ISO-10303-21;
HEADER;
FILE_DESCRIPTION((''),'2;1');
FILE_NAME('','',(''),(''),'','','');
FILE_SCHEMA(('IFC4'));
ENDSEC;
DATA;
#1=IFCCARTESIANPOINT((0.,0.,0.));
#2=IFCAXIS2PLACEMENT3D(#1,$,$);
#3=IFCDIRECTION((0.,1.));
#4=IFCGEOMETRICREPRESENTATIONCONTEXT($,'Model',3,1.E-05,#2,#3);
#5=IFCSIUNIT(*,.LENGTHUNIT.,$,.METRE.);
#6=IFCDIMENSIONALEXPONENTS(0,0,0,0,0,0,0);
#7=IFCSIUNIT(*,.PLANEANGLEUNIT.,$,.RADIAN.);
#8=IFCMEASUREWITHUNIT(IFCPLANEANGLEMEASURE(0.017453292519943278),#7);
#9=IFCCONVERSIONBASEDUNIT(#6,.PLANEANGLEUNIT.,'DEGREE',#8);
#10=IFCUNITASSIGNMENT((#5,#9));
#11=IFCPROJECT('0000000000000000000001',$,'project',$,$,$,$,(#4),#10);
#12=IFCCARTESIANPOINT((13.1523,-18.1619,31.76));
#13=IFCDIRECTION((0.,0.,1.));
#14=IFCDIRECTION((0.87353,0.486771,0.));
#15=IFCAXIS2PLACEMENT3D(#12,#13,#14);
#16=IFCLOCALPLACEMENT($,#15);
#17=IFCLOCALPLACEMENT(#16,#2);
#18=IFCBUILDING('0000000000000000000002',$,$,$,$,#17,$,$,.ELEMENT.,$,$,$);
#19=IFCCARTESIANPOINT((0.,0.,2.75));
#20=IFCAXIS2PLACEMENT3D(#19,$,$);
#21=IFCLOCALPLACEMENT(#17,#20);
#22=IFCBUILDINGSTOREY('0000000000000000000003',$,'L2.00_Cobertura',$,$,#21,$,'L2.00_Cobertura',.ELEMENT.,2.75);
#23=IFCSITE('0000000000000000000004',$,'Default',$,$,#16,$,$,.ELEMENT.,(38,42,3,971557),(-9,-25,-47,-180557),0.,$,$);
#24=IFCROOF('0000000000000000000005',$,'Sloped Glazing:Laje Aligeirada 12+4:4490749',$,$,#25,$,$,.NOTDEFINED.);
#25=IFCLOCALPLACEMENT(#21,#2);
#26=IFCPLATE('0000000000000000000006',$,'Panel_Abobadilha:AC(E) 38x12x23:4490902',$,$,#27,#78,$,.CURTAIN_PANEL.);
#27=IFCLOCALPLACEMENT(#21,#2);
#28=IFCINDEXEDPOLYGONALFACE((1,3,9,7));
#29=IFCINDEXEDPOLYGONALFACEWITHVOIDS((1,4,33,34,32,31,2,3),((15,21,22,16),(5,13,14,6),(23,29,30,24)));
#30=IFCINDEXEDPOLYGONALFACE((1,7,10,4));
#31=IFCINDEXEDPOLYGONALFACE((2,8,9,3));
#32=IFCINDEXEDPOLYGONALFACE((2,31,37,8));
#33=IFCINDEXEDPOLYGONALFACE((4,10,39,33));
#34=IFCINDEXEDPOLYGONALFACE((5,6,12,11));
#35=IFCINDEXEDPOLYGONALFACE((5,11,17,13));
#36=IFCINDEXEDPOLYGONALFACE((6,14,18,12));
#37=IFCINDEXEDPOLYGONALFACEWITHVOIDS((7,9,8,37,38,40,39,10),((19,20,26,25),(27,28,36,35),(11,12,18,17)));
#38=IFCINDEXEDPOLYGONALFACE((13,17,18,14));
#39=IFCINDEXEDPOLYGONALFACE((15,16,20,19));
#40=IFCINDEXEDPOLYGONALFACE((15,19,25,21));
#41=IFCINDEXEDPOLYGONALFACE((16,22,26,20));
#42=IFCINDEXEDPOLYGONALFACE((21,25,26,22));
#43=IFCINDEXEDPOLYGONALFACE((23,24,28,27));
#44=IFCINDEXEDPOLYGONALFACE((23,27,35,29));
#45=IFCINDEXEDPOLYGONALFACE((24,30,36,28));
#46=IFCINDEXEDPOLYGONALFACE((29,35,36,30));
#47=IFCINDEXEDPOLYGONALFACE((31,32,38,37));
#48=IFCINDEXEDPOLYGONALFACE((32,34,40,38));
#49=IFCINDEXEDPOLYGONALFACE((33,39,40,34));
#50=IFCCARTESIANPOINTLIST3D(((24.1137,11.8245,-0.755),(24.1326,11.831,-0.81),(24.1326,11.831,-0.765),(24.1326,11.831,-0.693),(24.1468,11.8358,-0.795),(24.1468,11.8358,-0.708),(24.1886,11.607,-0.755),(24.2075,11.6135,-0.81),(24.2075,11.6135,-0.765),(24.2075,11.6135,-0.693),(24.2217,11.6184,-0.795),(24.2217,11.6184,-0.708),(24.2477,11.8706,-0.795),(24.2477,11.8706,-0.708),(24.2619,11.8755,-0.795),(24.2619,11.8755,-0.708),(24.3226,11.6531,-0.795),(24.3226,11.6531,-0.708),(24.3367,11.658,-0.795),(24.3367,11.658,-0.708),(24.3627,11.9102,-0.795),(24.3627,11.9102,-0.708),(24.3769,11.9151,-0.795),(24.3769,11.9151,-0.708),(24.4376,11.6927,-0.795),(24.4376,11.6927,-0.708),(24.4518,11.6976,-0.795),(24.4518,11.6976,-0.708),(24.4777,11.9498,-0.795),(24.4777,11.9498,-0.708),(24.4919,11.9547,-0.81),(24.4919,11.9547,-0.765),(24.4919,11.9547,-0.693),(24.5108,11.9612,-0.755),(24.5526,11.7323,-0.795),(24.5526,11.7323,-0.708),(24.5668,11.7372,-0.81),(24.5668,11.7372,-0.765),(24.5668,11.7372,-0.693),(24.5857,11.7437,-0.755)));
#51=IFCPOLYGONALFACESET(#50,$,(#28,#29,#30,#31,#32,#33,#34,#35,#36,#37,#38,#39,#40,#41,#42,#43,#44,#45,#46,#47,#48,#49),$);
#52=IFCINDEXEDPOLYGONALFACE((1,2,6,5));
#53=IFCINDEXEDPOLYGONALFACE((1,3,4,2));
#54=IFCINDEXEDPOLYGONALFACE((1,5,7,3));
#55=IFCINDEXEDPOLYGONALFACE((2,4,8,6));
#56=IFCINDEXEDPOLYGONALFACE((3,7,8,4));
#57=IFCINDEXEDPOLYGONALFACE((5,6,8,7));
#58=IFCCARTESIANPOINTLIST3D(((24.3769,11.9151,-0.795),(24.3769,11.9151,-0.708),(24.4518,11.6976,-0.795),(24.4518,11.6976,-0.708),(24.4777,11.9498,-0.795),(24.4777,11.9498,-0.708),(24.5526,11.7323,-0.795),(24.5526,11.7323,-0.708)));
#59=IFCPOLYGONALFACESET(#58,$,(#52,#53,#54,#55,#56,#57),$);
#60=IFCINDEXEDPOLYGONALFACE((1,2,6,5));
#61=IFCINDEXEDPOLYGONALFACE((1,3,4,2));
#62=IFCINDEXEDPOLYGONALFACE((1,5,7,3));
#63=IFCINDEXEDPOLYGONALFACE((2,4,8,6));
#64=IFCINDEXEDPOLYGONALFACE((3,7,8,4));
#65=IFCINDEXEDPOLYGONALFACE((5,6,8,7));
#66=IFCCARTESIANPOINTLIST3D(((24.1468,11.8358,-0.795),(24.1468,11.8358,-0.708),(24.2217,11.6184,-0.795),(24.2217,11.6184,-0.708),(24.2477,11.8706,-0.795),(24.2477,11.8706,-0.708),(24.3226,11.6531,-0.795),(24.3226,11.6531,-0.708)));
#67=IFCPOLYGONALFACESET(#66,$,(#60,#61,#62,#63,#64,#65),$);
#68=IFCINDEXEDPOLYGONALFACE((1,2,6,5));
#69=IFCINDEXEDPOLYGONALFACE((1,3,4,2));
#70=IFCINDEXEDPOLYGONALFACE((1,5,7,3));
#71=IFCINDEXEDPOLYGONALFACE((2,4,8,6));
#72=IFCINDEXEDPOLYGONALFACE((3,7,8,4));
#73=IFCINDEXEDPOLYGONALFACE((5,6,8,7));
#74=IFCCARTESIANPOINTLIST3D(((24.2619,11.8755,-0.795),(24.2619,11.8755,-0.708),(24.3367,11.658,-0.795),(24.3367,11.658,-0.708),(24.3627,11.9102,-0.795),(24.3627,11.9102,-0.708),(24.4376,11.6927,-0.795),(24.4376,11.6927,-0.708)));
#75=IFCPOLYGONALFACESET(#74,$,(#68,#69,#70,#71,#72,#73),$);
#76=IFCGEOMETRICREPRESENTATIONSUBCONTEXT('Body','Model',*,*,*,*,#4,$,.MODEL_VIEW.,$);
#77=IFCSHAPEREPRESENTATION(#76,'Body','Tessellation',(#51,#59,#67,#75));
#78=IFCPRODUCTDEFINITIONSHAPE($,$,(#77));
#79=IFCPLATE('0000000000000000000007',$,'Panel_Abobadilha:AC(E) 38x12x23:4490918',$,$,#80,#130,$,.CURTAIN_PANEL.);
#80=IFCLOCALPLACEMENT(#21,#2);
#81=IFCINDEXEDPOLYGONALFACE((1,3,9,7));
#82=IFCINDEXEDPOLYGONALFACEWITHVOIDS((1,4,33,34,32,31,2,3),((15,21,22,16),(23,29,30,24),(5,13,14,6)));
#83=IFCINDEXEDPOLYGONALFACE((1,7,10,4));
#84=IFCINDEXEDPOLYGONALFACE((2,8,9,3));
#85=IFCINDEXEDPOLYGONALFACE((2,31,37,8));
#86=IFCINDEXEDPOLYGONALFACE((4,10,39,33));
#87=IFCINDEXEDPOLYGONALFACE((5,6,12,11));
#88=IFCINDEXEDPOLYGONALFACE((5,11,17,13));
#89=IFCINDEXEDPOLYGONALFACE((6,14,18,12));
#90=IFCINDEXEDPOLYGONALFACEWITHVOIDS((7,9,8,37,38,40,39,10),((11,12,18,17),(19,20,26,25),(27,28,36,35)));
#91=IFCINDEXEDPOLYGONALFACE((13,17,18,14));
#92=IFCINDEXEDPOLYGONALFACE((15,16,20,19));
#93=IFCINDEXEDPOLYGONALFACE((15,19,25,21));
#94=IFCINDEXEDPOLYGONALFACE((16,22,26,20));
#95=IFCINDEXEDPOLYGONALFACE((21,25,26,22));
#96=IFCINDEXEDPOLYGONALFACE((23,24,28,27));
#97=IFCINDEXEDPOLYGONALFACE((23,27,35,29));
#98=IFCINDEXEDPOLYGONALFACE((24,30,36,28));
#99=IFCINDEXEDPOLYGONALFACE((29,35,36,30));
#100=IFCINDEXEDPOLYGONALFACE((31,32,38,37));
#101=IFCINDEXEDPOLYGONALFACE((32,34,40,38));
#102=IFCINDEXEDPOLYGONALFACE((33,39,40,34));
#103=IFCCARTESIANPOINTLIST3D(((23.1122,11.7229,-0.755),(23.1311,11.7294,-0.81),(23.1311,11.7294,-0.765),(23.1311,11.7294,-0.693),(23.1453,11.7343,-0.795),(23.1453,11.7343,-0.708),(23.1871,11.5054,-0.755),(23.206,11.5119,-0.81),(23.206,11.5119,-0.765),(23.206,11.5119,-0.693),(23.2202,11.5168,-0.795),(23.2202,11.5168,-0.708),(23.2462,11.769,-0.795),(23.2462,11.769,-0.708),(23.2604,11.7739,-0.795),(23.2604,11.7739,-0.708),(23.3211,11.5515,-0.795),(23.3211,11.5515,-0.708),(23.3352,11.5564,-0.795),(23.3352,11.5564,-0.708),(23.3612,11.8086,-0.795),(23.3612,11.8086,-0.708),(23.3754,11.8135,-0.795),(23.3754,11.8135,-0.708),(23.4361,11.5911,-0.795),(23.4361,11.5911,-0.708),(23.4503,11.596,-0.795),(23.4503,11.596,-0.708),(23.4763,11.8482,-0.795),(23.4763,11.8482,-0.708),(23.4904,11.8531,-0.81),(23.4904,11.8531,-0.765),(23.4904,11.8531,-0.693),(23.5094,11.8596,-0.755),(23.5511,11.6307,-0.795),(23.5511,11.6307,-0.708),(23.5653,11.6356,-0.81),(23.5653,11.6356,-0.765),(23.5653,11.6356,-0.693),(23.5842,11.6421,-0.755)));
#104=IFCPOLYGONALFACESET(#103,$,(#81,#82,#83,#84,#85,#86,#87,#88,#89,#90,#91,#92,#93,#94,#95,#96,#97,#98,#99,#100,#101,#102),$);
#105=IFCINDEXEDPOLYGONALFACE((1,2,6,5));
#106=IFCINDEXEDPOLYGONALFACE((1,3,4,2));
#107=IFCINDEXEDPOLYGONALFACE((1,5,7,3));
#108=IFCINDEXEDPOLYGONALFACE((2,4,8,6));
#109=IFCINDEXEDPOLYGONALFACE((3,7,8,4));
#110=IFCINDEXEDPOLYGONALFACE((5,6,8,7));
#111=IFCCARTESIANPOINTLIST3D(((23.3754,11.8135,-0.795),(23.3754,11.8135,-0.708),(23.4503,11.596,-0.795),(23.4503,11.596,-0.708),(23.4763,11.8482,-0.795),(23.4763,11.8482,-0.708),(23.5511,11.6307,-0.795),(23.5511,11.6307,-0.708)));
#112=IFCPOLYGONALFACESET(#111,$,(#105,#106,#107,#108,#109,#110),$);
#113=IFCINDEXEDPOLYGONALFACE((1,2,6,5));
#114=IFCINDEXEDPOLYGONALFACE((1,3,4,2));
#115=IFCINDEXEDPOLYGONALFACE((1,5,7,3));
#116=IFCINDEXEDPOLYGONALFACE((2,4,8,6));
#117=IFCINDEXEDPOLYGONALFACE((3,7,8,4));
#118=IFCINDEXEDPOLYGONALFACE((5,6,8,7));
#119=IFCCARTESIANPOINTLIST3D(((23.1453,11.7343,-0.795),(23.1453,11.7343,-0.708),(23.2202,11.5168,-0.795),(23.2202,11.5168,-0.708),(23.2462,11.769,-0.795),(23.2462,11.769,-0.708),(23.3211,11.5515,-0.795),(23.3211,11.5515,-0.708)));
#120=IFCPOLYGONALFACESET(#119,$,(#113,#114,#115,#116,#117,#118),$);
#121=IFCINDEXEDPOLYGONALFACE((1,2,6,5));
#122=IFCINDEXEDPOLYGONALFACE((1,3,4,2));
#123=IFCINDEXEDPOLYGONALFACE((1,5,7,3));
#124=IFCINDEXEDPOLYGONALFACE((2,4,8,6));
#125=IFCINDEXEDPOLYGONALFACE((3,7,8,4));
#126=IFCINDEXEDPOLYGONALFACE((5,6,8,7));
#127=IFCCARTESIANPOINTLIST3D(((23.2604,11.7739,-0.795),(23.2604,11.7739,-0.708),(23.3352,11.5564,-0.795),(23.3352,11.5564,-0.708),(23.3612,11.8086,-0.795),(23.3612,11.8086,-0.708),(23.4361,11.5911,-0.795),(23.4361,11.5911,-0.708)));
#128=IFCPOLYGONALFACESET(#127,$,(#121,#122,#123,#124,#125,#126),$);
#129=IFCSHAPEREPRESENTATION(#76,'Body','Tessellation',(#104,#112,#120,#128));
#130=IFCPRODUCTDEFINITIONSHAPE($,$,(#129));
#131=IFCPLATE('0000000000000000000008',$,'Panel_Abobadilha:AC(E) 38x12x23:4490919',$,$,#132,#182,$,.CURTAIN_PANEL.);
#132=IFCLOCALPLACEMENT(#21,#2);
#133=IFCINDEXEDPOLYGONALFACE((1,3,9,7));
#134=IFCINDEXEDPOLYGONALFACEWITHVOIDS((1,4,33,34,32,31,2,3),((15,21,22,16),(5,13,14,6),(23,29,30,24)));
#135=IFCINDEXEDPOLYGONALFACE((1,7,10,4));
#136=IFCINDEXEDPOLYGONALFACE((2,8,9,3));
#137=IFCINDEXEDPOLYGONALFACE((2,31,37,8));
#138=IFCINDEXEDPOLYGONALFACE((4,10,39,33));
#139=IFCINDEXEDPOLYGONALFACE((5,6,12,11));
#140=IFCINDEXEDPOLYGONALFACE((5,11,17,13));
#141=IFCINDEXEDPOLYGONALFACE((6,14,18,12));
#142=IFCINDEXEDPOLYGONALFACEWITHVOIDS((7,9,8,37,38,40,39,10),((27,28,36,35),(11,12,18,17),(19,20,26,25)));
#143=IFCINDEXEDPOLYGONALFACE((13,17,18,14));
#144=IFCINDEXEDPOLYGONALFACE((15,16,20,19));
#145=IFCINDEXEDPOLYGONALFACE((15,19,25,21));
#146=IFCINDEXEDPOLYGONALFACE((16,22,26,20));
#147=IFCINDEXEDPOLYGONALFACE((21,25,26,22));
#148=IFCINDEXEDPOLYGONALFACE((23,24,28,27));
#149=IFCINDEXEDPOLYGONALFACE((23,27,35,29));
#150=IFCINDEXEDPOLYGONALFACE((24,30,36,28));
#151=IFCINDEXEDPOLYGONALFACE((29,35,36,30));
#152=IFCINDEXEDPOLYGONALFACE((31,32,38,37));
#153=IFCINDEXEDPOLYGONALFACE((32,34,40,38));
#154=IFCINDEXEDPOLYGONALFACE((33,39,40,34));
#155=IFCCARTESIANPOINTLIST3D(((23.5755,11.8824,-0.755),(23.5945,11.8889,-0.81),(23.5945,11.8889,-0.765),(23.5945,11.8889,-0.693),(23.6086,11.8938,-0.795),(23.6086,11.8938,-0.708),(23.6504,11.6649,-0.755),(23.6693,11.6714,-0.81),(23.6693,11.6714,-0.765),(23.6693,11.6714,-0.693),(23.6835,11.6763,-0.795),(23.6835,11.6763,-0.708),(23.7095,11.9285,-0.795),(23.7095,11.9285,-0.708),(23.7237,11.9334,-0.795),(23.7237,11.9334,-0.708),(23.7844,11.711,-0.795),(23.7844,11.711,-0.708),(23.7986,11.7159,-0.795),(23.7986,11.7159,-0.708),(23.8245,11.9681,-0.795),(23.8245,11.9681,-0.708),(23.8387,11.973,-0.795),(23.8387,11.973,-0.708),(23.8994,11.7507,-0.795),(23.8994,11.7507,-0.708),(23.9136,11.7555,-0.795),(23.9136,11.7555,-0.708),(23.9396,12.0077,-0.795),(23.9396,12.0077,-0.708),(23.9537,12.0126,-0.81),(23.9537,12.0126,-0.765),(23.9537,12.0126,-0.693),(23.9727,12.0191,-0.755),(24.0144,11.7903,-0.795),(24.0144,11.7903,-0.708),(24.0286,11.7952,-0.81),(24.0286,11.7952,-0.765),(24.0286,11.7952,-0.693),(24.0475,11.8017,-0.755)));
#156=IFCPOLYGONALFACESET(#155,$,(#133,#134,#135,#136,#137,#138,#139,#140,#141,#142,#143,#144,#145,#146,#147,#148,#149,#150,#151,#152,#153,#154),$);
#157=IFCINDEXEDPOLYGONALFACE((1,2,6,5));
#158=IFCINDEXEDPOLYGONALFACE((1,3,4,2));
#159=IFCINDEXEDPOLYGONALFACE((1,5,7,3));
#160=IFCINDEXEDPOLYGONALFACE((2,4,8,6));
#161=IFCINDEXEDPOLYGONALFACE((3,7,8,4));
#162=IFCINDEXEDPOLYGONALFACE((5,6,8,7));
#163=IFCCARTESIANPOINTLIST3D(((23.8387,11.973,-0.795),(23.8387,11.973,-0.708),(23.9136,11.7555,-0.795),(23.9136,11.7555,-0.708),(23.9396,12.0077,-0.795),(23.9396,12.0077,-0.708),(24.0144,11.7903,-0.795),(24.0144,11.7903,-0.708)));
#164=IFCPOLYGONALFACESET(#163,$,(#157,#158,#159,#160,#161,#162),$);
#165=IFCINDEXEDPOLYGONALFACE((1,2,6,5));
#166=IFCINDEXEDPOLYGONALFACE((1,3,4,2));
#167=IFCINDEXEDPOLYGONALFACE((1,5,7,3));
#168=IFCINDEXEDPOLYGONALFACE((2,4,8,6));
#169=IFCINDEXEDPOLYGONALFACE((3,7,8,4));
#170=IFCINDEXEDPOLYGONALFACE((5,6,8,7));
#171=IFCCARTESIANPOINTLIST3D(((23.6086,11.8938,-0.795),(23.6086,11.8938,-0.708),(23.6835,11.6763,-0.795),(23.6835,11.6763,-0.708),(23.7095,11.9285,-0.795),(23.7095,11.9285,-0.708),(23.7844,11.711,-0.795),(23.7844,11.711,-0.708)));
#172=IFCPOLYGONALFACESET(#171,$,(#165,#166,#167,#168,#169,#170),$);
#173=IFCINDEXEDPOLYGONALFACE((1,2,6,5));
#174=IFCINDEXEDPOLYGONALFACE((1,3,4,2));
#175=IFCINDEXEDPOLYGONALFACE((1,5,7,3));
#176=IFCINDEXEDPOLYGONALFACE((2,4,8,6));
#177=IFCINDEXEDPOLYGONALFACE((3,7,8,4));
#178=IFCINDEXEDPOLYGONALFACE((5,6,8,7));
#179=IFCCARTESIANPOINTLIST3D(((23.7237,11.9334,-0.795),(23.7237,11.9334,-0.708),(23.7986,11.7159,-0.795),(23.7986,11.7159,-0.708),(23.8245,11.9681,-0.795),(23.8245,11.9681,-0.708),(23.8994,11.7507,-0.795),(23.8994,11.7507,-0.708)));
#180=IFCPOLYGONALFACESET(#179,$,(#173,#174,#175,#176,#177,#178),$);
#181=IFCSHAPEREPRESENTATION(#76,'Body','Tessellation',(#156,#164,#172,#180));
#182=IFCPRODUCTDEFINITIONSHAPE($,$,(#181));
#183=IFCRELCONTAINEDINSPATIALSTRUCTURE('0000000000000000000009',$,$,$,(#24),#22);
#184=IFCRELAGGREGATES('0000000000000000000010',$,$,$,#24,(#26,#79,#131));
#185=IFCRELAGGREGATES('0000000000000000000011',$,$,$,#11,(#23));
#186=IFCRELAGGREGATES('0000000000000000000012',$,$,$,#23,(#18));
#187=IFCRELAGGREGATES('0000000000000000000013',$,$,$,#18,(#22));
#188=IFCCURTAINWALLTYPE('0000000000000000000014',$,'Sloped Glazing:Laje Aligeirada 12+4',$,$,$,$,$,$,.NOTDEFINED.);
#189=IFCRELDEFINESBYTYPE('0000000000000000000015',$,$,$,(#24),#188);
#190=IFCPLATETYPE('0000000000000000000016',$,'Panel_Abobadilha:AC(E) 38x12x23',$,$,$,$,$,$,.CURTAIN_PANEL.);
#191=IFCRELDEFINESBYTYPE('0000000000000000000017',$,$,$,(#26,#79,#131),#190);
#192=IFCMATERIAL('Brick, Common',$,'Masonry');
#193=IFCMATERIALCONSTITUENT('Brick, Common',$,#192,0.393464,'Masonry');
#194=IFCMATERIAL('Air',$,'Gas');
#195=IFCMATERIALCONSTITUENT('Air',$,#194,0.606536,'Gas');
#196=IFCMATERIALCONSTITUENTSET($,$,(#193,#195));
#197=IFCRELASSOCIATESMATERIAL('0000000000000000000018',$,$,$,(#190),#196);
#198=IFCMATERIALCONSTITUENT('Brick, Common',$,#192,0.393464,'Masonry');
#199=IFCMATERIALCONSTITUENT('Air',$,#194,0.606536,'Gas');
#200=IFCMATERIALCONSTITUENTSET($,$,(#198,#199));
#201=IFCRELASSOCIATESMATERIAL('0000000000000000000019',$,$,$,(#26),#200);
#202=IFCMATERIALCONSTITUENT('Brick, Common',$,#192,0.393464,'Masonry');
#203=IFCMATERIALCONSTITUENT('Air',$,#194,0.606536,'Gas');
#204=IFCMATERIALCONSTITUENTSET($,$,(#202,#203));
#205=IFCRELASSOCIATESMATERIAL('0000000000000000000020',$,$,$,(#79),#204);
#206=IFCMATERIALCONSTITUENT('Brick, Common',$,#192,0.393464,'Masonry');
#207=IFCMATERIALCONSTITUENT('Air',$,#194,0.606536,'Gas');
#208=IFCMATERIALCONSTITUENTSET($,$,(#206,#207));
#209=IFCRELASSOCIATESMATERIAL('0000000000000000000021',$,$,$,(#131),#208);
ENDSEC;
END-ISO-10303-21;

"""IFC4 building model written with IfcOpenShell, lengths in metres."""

from ifc_helpers import new_model, entity, si_unit, converted_unit, direction, frame, origin, place, context, subcontext, project, spatial, indexed_curve, outline, extrude, source, transform, mapped, material, constituent, constituent_set, type_object, type_shapes, element, aggregate, save


model = new_model("IFC4")

# Units and contexts
model_context = context("Model", 3, precision=1e-05, world=origin(), true_north=direction((0.0, 1.0)))
body_context = subcontext(model_context, "Body", "Model", "MODEL_VIEW")
ifc_project = project(units=[si_unit("LENGTHUNIT", "METRE"), converted_unit("PLANEANGLEUNIT", "DEGREE", entity("IfcPlaneAngleMeasure", 0.017453292519943278), si_unit("PLANEANGLEUNIT", "RADIAN"), dimensions=[0, 0, 0, 0, 0, 0, 0])], contexts=[model_context])

# Site, building, storey
site_placement = place(None, frame((13.1523, -18.1619, 31.76), z_axis=(0.0, 0.0, 1.0), x_axis=(0.87353, 0.486771, 0.0)))
site = spatial("IfcSite", under=ifc_project, at=site_placement, Name="Default", CompositionType="ELEMENT", RefLatitude=(38, 42, 3, 971557), RefLongitude=(-9, -25, -47, -180557), RefElevation=0.0)
building_placement = place(site_placement, origin())
building = spatial("IfcBuilding", under=site, at=building_placement, CompositionType="ELEMENT")
storey_placement = place(building_placement, frame((0.0, 0.0, 2.75)))
storey = spatial("IfcBuildingStorey", under=building, at=storey_placement, Name="L2.00_Cobertura", LongName="L2.00_Cobertura", CompositionType="ELEMENT", Elevation=2.75)

# Roof, plates
curtain_wall_type = type_object("IfcCurtainWallType", Name="Sloped Glazing:Laje Aligeirada 12+4", PredefinedType="NOTDEFINED")
roof_placement = place(storey_placement, frame((0.0, 0.0, -2.75)))
roof = element("IfcRoof", 1, at=roof_placement, inside=storey, type_object=curtain_wall_type, Name="Sloped Glazing:Laje Aligeirada 12+4:4490749", PredefinedType="NOTDEFINED")
ifc_material_1 = material(Name="Brick, Common", Category="Masonry")
ifc_material_2 = material(Name="Air", Category="Gas")
ifc_constituent_1 = constituent(ifc_material_1, Name="Brick, Common", Category="Masonry", fraction=0.393464)
ifc_constituent_2 = constituent(ifc_material_2, Name="Air", Category="Gas", fraction=0.606536)
ifc_constituent_set_1 = constituent_set(constituents=[ifc_constituent_1, ifc_constituent_2])
plate_type_1 = type_object("IfcPlateType", Name="Panel_Abobadilha:AC(E) 38x12x23", PredefinedType="CURTAIN_PANEL", material=ifc_constituent_set_1)
shared_shape_1 = source(origin(), body_context, "Body", "SweptSolid", [
    extrude(outline(indexed_curve([(-0.19, -0.0543), (0.19, -0.0543), (0.19, -0.0093), (0.21, 0.0007), (0.19, 0.0628), (-0.19, 0.0628), (-0.21, 0.0007), (-0.19, -0.0093), (-0.19, -0.0543)], self_intersect=False), holes=[indexed_curve([(-0.0683, 0.0477), (-0.0683, -0.0393), (-0.175, -0.0393), (-0.175, 0.0477), (-0.0683, 0.0477)], self_intersect=False), indexed_curve([(0.0533, 0.0477), (0.0533, -0.0393), (-0.0533, -0.0393), (-0.0533, 0.0477), (0.0533, 0.0477)], self_intersect=False), indexed_curve([(0.175, 0.0477), (0.175, -0.0393), (0.0683, -0.0393), (0.0683, 0.0477), (0.175, 0.0477)], self_intersect=False)]), frame((0.0, 0.0543, 0.0)), (0.0, 0.0, 1.0), 0.23),
    extrude(outline(indexed_curve([(-0.0533, -0.0435), (0.0533, -0.0435), (0.0533, 0.0435), (-0.0533, 0.0435), (-0.0533, -0.0435)], self_intersect=False)), frame((0.1217, 0.0585, 0.0), z_axis=(0.0, 0.0, 1.0), x_axis=(-1.0, 0.0, 0.0)), (0.0, 0.0, 1.0), 0.23),
    extrude(outline(indexed_curve([(-0.0533, -0.0435), (0.0533, -0.0435), (0.0533, 0.0435), (-0.0533, 0.0435), (-0.0533, -0.0435)], self_intersect=False)), frame((-0.1217, 0.0585, 0.0), z_axis=(0.0, 0.0, 1.0), x_axis=(-1.0, 0.0, 0.0)), (0.0, 0.0, 1.0), 0.23),
    extrude(outline(indexed_curve([(-0.0533, -0.0435), (0.0533, -0.0435), (0.0533, 0.0435), (-0.0533, 0.0435), (-0.0533, -0.0435)], self_intersect=False)), frame((0.0, 0.0585, 0.0), z_axis=(0.0, 0.0, 1.0), x_axis=(-1.0, 0.0, 0.0)), (0.0, 0.0, 1.0), 0.23),
])
type_shapes(plate_type_1, [shared_shape_1])
ifc_constituent_3 = constituent(ifc_material_1, Name="Brick, Common", Category="Masonry", fraction=0.393464)
ifc_constituent_4 = constituent(ifc_material_2, Name="Air", Category="Gas", fraction=0.606536)
ifc_constituent_set_2 = constituent_set(constituents=[ifc_constituent_3, ifc_constituent_4])
plate_1_placement = place(roof_placement, frame((24.3123, 11.8928, 1.94), z_axis=(0.325568, -0.945519, 0.0), x_axis=(0.945519, 0.325568, 0.0)))
plate_1 = element("IfcPlate", 2, at=plate_1_placement, type_object=plate_type_1, material=ifc_constituent_set_2, Name="Panel_Abobadilha:AC(E) 38x12x23:4490902", PredefinedType="CURTAIN_PANEL", context=body_context, shape_type="MappedRepresentation", body=[
    mapped(shared_shape_1, transform((0.0, 0.0, 0.0), scale=1.0)),
])
ifc_constituent_5 = constituent(ifc_material_1, Name="Brick, Common", Category="Masonry", fraction=0.393464)
ifc_constituent_6 = constituent(ifc_material_2, Name="Air", Category="Gas", fraction=0.606536)
ifc_constituent_set_3 = constituent_set(constituents=[ifc_constituent_5, ifc_constituent_6])
plate_2_placement = place(roof_placement, frame((23.3108, 11.7912, 1.94), z_axis=(0.325568, -0.945519, 0.0), x_axis=(0.945519, 0.325568, 0.0)))
plate_2 = element("IfcPlate", 3, at=plate_2_placement, type_object=plate_type_1, material=ifc_constituent_set_3, Name="Panel_Abobadilha:AC(E) 38x12x23:4490918", PredefinedType="CURTAIN_PANEL", context=body_context, shape_type="MappedRepresentation", body=[
    mapped(shared_shape_1, transform((0.0, 0.0, 0.0), scale=1.0)),
])
ifc_constituent_7 = constituent(ifc_material_1, Name="Brick, Common", Category="Masonry", fraction=0.393464)
ifc_constituent_8 = constituent(ifc_material_2, Name="Air", Category="Gas", fraction=0.606536)
ifc_constituent_set_4 = constituent_set(constituents=[ifc_constituent_7, ifc_constituent_8])
plate_3_placement = place(roof_placement, frame((23.7741, 11.9508, 1.94), z_axis=(0.325568, -0.945519, 0.0), x_axis=(0.945519, 0.325568, 0.0)))
plate_3 = element("IfcPlate", 4, at=plate_3_placement, type_object=plate_type_1, material=ifc_constituent_set_4, Name="Panel_Abobadilha:AC(E) 38x12x23:4490919", PredefinedType="CURTAIN_PANEL", context=body_context, shape_type="MappedRepresentation", body=[
    mapped(shared_shape_1, transform((0.0, 0.0, 0.0), scale=1.0)),
])
aggregate(roof, [plate_1, plate_2, plate_3])

save(model, "model.ifc")
